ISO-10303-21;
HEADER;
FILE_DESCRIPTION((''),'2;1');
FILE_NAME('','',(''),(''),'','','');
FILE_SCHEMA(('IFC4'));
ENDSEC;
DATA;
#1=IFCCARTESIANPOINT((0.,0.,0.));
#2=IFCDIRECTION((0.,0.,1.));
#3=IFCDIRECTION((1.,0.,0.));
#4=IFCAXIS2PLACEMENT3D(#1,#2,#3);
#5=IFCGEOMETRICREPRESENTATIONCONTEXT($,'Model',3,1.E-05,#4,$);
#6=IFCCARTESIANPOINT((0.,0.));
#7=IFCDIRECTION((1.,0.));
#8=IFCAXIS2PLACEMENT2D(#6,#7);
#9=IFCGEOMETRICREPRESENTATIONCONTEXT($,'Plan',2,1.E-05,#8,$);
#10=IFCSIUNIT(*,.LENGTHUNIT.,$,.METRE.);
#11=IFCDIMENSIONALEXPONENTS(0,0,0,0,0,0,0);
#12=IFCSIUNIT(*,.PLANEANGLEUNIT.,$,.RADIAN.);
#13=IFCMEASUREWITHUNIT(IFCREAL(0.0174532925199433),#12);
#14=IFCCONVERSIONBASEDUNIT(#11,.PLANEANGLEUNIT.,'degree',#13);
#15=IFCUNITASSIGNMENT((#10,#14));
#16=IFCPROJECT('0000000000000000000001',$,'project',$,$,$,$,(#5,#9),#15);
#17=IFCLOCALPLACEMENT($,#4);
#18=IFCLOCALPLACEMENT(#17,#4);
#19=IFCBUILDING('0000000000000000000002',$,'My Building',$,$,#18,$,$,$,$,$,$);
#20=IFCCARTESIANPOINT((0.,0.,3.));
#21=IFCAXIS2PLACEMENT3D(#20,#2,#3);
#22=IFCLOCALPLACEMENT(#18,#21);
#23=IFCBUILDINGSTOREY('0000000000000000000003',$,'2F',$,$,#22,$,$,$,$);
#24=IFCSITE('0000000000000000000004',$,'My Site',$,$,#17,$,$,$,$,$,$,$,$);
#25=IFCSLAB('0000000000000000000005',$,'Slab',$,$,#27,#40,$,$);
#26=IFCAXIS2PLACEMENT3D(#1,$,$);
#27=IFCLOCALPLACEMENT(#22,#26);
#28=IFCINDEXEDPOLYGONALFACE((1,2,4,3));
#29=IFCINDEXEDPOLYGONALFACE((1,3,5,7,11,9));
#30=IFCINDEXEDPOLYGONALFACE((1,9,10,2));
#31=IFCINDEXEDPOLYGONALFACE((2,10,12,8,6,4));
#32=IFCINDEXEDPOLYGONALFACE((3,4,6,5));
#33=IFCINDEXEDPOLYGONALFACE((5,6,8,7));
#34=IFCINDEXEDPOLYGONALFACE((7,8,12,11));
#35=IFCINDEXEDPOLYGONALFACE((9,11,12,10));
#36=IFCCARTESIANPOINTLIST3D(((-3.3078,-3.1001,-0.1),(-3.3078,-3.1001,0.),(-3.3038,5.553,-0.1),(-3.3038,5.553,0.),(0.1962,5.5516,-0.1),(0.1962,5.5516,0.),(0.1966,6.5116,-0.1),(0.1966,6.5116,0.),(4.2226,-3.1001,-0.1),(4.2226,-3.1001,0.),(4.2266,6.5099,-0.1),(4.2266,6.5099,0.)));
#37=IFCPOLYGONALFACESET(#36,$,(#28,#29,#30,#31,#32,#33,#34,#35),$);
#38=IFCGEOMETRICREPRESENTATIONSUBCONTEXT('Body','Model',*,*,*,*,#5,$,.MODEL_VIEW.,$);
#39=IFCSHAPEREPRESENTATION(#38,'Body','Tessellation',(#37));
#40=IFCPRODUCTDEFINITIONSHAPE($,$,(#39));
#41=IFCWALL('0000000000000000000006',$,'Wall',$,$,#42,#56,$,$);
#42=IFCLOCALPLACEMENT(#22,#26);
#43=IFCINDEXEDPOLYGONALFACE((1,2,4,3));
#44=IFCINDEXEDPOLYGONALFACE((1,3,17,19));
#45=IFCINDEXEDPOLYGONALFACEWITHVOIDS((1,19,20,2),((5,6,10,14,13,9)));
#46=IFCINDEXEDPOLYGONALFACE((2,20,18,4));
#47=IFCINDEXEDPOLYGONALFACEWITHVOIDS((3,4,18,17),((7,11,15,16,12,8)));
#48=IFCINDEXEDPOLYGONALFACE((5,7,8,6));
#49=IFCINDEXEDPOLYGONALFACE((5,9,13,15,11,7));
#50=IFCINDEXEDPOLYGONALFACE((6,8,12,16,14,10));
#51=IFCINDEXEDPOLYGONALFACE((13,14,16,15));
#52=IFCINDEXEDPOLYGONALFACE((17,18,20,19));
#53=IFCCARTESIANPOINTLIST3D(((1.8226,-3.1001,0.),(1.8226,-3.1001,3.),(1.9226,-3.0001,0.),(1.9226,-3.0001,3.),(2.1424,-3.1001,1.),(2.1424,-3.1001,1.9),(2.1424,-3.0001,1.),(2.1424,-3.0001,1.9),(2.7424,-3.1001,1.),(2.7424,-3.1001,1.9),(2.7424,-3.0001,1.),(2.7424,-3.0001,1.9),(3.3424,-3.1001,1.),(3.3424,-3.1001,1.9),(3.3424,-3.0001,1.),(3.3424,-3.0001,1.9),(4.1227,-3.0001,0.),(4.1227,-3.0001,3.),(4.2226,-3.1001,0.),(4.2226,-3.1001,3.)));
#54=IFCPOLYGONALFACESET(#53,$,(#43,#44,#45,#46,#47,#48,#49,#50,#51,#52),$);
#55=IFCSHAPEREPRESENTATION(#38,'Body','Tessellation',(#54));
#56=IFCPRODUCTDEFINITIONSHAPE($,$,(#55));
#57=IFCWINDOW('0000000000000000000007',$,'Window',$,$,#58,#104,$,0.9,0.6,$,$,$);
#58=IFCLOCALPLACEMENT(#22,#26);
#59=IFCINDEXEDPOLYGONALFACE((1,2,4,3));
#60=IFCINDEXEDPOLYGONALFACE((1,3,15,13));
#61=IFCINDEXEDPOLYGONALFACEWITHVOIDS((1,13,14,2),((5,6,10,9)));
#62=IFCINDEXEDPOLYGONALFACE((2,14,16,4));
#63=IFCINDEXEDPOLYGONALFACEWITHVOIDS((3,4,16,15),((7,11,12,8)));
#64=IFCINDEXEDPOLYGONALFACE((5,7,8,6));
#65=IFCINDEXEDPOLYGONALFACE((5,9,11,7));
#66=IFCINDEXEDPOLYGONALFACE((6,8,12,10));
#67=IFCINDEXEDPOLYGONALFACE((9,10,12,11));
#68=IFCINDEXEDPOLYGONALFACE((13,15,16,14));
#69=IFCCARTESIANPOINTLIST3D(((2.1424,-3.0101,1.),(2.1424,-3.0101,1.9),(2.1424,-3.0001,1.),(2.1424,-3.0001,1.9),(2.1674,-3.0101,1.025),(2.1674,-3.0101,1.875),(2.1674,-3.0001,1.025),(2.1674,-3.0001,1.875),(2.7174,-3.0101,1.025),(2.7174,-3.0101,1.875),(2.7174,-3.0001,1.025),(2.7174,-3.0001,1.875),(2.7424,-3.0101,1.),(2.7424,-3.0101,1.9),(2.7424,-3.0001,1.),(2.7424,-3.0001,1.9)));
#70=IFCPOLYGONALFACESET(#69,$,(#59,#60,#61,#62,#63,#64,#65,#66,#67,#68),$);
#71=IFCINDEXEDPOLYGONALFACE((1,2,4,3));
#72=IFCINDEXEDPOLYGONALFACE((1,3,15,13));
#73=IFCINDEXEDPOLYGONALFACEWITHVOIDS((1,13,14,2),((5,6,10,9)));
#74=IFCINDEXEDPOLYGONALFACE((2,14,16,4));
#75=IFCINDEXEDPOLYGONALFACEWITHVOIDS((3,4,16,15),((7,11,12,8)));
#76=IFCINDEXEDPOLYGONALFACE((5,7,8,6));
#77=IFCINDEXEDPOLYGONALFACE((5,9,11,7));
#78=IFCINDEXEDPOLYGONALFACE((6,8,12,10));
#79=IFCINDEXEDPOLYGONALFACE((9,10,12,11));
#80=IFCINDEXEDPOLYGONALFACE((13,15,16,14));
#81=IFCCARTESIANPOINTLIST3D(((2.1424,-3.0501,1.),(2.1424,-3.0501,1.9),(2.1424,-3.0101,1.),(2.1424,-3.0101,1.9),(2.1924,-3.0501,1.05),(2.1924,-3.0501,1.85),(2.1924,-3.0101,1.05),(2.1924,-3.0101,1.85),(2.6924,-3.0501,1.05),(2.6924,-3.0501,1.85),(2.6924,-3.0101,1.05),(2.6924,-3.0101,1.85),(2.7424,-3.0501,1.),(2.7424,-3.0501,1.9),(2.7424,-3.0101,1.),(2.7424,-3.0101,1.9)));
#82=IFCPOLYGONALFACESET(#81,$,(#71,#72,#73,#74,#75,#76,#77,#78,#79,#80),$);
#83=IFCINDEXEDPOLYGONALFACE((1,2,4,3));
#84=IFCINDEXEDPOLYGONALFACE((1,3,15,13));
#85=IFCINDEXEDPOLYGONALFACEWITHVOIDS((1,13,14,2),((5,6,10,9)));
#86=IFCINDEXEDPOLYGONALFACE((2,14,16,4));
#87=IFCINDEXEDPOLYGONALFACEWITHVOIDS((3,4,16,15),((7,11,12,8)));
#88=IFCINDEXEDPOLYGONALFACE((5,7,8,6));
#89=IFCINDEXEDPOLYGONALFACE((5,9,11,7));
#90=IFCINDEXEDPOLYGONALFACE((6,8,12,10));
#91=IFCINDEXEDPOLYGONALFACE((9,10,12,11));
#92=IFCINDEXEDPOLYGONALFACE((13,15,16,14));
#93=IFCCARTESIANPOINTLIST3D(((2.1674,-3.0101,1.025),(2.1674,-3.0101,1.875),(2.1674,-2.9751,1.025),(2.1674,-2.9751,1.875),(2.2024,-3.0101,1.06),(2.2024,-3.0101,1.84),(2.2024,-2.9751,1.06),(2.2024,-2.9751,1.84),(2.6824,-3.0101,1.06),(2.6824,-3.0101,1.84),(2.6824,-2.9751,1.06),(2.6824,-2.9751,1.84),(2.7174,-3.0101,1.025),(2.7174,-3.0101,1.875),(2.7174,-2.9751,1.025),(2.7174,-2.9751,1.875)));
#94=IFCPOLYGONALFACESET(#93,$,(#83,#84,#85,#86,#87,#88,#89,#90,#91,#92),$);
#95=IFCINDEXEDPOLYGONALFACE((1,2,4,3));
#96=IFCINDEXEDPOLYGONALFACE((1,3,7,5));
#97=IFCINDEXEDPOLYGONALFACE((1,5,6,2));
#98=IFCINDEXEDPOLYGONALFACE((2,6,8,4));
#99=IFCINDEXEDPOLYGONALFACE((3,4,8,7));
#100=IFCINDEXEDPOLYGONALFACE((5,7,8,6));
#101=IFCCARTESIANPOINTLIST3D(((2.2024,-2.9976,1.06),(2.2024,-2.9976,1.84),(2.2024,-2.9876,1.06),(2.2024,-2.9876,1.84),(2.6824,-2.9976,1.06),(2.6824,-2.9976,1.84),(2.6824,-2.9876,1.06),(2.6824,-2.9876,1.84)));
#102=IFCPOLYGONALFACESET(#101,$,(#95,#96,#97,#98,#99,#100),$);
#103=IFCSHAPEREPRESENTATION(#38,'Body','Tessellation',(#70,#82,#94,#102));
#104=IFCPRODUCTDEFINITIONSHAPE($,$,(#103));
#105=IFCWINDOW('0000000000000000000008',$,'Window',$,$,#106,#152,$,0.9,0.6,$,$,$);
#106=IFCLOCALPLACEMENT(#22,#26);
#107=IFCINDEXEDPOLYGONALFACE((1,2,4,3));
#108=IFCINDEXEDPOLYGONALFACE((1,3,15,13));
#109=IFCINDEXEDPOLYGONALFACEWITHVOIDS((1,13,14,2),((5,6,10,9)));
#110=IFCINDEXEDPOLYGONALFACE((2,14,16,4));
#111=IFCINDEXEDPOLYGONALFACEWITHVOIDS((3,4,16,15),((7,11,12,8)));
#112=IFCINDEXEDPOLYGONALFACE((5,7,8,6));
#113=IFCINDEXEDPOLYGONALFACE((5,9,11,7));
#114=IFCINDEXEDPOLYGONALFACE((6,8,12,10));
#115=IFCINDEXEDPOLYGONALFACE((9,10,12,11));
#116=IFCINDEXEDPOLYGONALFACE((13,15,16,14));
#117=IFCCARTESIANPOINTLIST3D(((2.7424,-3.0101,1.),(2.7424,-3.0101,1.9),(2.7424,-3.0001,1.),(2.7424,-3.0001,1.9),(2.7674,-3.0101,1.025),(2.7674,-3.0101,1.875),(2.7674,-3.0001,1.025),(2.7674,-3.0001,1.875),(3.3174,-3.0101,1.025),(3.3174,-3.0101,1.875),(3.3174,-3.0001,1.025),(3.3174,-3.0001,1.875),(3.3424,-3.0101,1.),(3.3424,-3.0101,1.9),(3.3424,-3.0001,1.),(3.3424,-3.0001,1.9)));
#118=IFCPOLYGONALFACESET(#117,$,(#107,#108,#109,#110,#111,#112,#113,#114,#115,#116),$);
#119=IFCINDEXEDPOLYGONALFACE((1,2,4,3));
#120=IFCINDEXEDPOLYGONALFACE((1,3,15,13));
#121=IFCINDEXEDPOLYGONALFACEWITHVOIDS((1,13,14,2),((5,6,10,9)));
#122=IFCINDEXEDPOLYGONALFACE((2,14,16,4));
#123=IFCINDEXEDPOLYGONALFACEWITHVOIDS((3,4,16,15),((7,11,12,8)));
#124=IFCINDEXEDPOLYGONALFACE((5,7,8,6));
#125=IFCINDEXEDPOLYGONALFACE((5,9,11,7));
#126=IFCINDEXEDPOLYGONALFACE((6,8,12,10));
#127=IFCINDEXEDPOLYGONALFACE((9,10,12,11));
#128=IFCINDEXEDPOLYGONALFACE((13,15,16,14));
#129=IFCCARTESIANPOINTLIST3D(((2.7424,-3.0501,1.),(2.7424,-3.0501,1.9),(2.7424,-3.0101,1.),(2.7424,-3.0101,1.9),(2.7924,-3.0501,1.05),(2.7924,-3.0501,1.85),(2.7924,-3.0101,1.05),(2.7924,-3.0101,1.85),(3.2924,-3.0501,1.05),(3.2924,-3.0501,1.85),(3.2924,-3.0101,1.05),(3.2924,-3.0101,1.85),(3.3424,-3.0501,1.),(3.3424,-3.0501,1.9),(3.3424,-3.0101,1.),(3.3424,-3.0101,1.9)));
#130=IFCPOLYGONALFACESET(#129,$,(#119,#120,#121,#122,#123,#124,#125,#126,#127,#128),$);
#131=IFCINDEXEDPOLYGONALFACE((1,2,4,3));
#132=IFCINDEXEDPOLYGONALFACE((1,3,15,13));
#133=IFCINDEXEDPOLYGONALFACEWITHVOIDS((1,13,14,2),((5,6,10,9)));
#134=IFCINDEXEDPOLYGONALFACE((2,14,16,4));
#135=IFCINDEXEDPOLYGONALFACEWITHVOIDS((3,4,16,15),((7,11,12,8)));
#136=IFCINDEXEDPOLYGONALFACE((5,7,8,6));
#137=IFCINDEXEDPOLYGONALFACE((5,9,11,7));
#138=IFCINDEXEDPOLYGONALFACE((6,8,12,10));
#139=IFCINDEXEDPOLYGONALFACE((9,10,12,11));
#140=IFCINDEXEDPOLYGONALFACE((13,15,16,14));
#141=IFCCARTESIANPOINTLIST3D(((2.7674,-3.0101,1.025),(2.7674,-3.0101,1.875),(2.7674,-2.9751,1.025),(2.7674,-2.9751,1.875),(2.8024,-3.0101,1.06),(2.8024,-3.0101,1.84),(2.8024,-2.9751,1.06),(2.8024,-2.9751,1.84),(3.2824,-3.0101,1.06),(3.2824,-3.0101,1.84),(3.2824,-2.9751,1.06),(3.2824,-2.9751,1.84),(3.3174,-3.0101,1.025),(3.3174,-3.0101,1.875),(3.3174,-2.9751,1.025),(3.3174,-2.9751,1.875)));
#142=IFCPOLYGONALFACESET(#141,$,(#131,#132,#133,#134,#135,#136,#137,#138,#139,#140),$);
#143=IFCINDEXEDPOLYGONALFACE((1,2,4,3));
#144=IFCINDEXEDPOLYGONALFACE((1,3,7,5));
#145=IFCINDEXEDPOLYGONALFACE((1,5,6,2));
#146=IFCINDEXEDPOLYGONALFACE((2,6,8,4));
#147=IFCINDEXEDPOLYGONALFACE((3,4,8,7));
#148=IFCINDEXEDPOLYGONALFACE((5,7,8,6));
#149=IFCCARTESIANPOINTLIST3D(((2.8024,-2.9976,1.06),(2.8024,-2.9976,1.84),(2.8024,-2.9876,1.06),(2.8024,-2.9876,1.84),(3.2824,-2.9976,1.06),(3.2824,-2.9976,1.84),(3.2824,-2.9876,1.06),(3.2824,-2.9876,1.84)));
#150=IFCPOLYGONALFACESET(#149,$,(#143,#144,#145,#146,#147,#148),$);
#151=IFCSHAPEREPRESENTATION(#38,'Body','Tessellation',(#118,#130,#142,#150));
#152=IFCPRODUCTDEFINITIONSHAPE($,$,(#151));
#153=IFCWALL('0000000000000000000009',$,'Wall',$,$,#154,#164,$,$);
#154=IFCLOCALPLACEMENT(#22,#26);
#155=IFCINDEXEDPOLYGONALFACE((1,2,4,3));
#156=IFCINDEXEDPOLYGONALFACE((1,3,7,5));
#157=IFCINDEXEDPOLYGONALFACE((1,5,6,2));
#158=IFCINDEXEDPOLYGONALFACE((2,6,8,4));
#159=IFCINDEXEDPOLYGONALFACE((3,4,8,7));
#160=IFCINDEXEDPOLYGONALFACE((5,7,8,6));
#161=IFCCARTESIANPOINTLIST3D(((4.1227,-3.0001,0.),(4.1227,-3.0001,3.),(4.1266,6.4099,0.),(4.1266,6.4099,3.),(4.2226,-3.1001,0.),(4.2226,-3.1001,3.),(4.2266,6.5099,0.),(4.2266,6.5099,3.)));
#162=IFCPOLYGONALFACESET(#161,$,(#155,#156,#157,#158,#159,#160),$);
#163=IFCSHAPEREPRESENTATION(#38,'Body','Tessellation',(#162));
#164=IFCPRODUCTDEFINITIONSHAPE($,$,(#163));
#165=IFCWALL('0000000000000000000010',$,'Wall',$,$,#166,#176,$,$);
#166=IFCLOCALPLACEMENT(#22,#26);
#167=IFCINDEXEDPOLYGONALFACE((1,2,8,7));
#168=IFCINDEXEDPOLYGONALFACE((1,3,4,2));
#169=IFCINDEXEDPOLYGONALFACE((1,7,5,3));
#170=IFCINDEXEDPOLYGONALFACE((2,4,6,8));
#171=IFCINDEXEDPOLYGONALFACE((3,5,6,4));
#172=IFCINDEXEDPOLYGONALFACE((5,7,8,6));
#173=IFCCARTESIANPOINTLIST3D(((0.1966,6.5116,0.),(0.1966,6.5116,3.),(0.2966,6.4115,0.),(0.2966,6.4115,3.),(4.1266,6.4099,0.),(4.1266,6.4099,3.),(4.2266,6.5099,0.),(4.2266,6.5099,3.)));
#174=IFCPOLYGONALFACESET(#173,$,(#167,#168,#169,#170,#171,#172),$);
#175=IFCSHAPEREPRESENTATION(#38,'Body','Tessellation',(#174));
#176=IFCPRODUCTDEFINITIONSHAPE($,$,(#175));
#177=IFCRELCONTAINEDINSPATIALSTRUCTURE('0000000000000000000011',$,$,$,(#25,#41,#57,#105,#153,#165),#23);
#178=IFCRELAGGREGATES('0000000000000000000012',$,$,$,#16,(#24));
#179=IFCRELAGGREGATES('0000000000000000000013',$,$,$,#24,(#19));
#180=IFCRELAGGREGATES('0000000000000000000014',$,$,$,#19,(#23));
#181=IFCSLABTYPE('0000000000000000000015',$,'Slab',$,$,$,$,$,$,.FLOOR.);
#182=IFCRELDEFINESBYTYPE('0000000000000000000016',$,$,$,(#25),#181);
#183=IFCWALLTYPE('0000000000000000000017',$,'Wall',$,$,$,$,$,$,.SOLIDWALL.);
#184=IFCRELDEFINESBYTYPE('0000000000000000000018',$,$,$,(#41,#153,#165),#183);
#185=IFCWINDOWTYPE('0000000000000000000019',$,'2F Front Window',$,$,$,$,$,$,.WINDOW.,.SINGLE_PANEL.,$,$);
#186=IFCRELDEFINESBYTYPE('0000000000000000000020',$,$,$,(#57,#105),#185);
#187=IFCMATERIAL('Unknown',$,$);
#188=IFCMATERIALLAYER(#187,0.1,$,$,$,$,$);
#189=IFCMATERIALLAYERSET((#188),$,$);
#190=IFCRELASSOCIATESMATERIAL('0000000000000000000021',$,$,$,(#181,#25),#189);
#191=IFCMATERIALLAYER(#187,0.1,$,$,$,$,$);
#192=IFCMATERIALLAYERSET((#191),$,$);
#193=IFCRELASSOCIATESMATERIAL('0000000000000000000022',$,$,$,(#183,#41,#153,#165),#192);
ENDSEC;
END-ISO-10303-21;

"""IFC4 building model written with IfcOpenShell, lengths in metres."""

from ifc_helpers import new_model, entity, si_unit, converted_unit, frame, origin_with_axes, origin_2d_with_axis, place, context, subcontext, project, spatial, line, indexed_curve, outline, extrude, shape, source, transform, mapped, material, layer, layer_set, layer_usage, type_object, type_shapes, element, fill, save


model = new_model("IFC4")

# Units and contexts
model_context = context("Model", 3, precision=1e-05, world=origin_with_axes())
plan_context = context("Plan", 2, precision=1e-05, world=origin_2d_with_axis())
body_context_1 = subcontext(model_context, "Body", "Model", "MODEL_VIEW")
body_context_2 = subcontext(plan_context, "Body", "Plan", "PLAN_VIEW")
ifc_project = project(units=[si_unit("LENGTHUNIT", "METRE"), converted_unit("PLANEANGLEUNIT", "degree", entity("IfcReal", 0.0174532925199433), si_unit("PLANEANGLEUNIT", "RADIAN"), dimensions=[0, 0, 0, 0, 0, 0, 0])], contexts=[model_context, plan_context])

# Site, building, storey
site_placement = place(None, origin_with_axes())
site = spatial("IfcSite", under=ifc_project, at=site_placement, Name="My Site")
building_placement = place(site_placement, origin_with_axes())
building = spatial("IfcBuilding", under=site, at=building_placement, Name="My Building")
storey_placement = place(building_placement, frame((0.0, 0.0, 3.0), z_axis=(0.0, 0.0, 1.0), x_axis=(1.0, 0.0, 0.0)))
storey = spatial("IfcBuildingStorey", under=building, at=storey_placement, Name="2F")

# Slab
ifc_material = material(Name="Unknown")
ifc_layer_1 = layer(ifc_material, 0.1)
ifc_layer_set_1 = layer_set([ifc_layer_1])
ifc_layer_usage_1 = layer_usage(ifc_layer_set_1, "AXIS3", "POSITIVE", -0.1)
slab_type = type_object("IfcSlabType", Name="Slab", PredefinedType="FLOOR", material=ifc_layer_set_1)
slab_placement = place(storey_placement, frame((-3.3078, -3.1001, 0.0), z_axis=(0.0, 0.0, 1.0), x_axis=(1.0, 0.0, 0.0)))
element("IfcSlab", 1, at=slab_placement, inside=storey, type_object=slab_type, material=ifc_layer_usage_1, Name="Slab", context=body_context_1, shape_type="SweptSolid", body=[
    extrude(outline(indexed_curve([(0.0, 0.0), (7.5304, 0.0), (7.5344, 9.61), (3.5044, 9.6117), (3.504, 8.6517), (0.004, 8.6531), (0.0, 0.0)])), frame((0.0, 0.0, -0.1), z_axis=(0.0, 0.0, 1.0), x_axis=(1.0, 0.0, 0.0)), (0.0, 0.0, 1.0), 0.1),
])

# Wall, openings, windows
ifc_layer_2 = layer(ifc_material, 0.1)
ifc_layer_set_2 = layer_set([ifc_layer_2])
ifc_layer_usage_2 = layer_usage(ifc_layer_set_2, "AXIS2", "POSITIVE", 0.0)
wall_type = type_object("IfcWallType", Name="Wall", PredefinedType="SOLIDWALL", material=ifc_layer_set_2)
wall_1_placement = place(storey_placement, frame((1.8226, -3.1001, 0.0), z_axis=(0.0, 0.0, 1.0), x_axis=(1.0, 0.0, 0.0)))
wall_1 = element("IfcWall", 2, at=wall_1_placement, inside=storey, type_object=wall_type, material=ifc_layer_usage_2, Name="Wall", context=body_context_1, shape_type="SweptSolid", body=[
    extrude(outline(indexed_curve([(0.0, 0.0), (0.1, 0.1), (2.3, 0.1), (2.4, 0.0)], segments=[line(1, 2, 3, 4, 1)])), origin_with_axes(), (0.0, 0.0, 1.0), 3.0),
])
shared_shape_1 = source(origin_with_axes(), body_context_1, "Body", "SweptSolid", [
    extrude(outline(indexed_curve([(0.0, 0.0), (0.6, 0.0), (0.6, 0.9), (0.0, 0.9)], segments=[line(1, 2, 3, 4, 1)])), frame((0.0, -0.6, 0.0), z_axis=(0.0, -1.0, 0.0), x_axis=(1.0, 0.0, 0.0)), (0.0, 0.0, -1.0), 1.2),
])
opening_1_placement = place(wall_1_placement, frame((0.3197, 0.0, 1.0), z_axis=(0.0, 0.0, 1.0), x_axis=(1.0, 0.0, 0.0)))
opening_1 = element("IfcOpeningElement", 3, at=opening_1_placement, cuts=wall_1, PredefinedType="OPENING", context=body_context_1, shape_type="MappedRepresentation", body=[
    mapped(shared_shape_1, transform((0.0, 0.0, 0.0), x_axis=(1.0, 0.0, 0.0), y_axis=(0.0, 1.0, 0.0), z_axis=(0.0, 0.0, 1.0), scale=1.0)),
])
opening_2_placement = place(wall_1_placement, frame((0.9197, 0.0, 1.0), z_axis=(0.0, 0.0, 1.0), x_axis=(1.0, 0.0, 0.0)))
opening_2 = element("IfcOpeningElement", 4, at=opening_2_placement, cuts=wall_1, PredefinedType="OPENING", context=body_context_1, shape_type="MappedRepresentation", body=[
    mapped(shared_shape_1, transform((0.0, 0.0, 0.0), x_axis=(1.0, 0.0, 0.0), y_axis=(0.0, 1.0, 0.0), z_axis=(0.0, 0.0, 1.0), scale=1.0)),
])
window_type_1 = type_object("IfcWindowType", Name="2F Front Window", PartitioningType="SINGLE_PANEL", PredefinedType="WINDOW")
shared_shape_2 = source(origin_with_axes(), body_context_1, "Body", "SweptSolid", [
    extrude(outline(indexed_curve([(0.0, 0.0), (0.6, 0.0), (0.6, 0.9), (0.0, 0.9)], segments=[line(1, 2, 3, 4, 1)]), holes=[indexed_curve([(0.025, 0.025), (0.575, 0.025), (0.575, 0.875), (0.025, 0.875)], segments=[line(1, 2, 3, 4, 1)])]), frame((0.0, 0.09, 0.0), z_axis=(0.0, -1.0, 0.0), x_axis=(1.0, 0.0, 0.0)), (0.0, 0.0, -1.0), 0.01),
    extrude(outline(indexed_curve([(0.0, 0.0), (0.6, 0.0), (0.6, 0.9), (0.0, 0.9)], segments=[line(1, 2, 3, 4, 1)]), holes=[indexed_curve([(0.05, 0.05), (0.55, 0.05), (0.55, 0.85), (0.05, 0.85)], segments=[line(1, 2, 3, 4, 1)])]), frame((0.0, 0.05, 0.0), z_axis=(0.0, -1.0, 0.0), x_axis=(1.0, 0.0, 0.0)), (0.0, 0.0, -1.0), 0.04),
    extrude(outline(indexed_curve([(0.0, 0.0), (0.55, 0.0), (0.55, 0.85), (0.0, 0.85)], segments=[line(1, 2, 3, 4, 1)]), holes=[indexed_curve([(0.035, 0.035), (0.515, 0.035), (0.515, 0.815), (0.035, 0.815)], segments=[line(1, 2, 3, 4, 1)])]), frame((0.025, 0.09, 0.025), z_axis=(0.0, -1.0, 0.0), x_axis=(1.0, 0.0, 0.0)), (0.0, 0.0, -1.0), 0.035),
    extrude(outline(indexed_curve([(0.035, 0.035), (0.515, 0.035), (0.515, 0.815), (0.035, 0.815)], segments=[line(1, 2, 3, 4, 1)])), frame((0.025, 0.1025, 0.025), z_axis=(0.0, -1.0, 0.0), x_axis=(1.0, 0.0, 0.0)), (0.0, 0.0, -1.0), 0.01),
])
shared_shape_3 = source(origin_with_axes(), body_context_2, "Body", "Curve2D", [
    entity("IfcIndexedPolyCurve", entity("IfcCartesianPointList2D", [[0.05, 0.05], [0.55, 0.05]])),
    entity("IfcIndexedPolyCurve", entity("IfcCartesianPointList2D", [[0.0, 0.1], [0.025, 0.1], [0.025, 0.09], [0.05, 0.09], [0.05, 0.05], [0.0, 0.05]]), [entity("IfcLineIndex", [1, 2, 3, 4, 5, 6, 1])]),
    entity("IfcIndexedPolyCurve", entity("IfcCartesianPointList2D", [[0.6, 0.1], [0.575, 0.1], [0.575, 0.09], [0.55, 0.09], [0.55, 0.05], [0.6, 0.05]]), [entity("IfcLineIndex", [1, 2, 3, 4, 5, 6, 1])]),
    entity("IfcIndexedPolyCurve", entity("IfcCartesianPointList2D", [[0.025, 0.09], [0.06, 0.09], [0.06, 0.125], [0.025, 0.125]]), [entity("IfcLineIndex", [1, 2, 3, 4, 1])]),
    entity("IfcIndexedPolyCurve", entity("IfcCartesianPointList2D", [[0.575, 0.09], [0.54, 0.09], [0.54, 0.125], [0.575, 0.125]]), [entity("IfcLineIndex", [1, 2, 3, 4, 1])]),
    entity("IfcIndexedPolyCurve", entity("IfcCartesianPointList2D", [[0.06, 0.09], [0.54, 0.09]])),
    entity("IfcIndexedPolyCurve", entity("IfcCartesianPointList2D", [[0.06, 0.125], [0.54, 0.125]])),
    entity("IfcIndexedPolyCurve", entity("IfcCartesianPointList2D", [[0.06, 0.1075], [0.54, 0.1075]])),
])
type_shapes(window_type_1, [shared_shape_2, shared_shape_3])
window_1_placement = place(opening_1_placement, origin_with_axes())
window_1 = element("IfcWindow", 5, at=window_1_placement, inside=storey, type_object=window_type_1, Name="Window", OverallHeight=0.9, OverallWidth=0.6, shapes=[
    shape(body_context_1, "Body", "MappedRepresentation", [mapped(shared_shape_2, transform((0.0, 0.0, 0.0), x_axis=(1.0, 0.0, 0.0), y_axis=(0.0, 1.0, 0.0), z_axis=(0.0, 0.0, 1.0), scale=1.0))]),
    shape(body_context_2, "Body", "MappedRepresentation", [mapped(shared_shape_3, transform((0.0, 0.0, 0.0), x_axis=(1.0, 0.0, 0.0), y_axis=(0.0, 1.0, 0.0), z_axis=(0.0, 0.0, 1.0), scale=1.0))]),
])
fill(opening_1, window_1)
window_2_placement = place(opening_2_placement, origin_with_axes())
window_2 = element("IfcWindow", 6, at=window_2_placement, inside=storey, type_object=window_type_1, Name="Window", OverallHeight=0.9, OverallWidth=0.6, shapes=[
    shape(body_context_1, "Body", "MappedRepresentation", [mapped(shared_shape_2, transform((0.0, 0.0, 0.0), x_axis=(1.0, 0.0, 0.0), y_axis=(0.0, 1.0, 0.0), z_axis=(0.0, 0.0, 1.0), scale=1.0))]),
    shape(body_context_2, "Body", "MappedRepresentation", [mapped(shared_shape_3, transform((0.0, 0.0, 0.0), x_axis=(1.0, 0.0, 0.0), y_axis=(0.0, 1.0, 0.0), z_axis=(0.0, 0.0, 1.0), scale=1.0))]),
])
fill(opening_2, window_2)

# Walls
ifc_layer_usage_3 = layer_usage(ifc_layer_set_2, "AXIS2", "POSITIVE", 0.0)
wall_2_placement = place(storey_placement, frame((4.2226, -3.1001, 0.0), z_axis=(0.0, 0.0, 1.0), x_axis=(0.000415, 1.0, 0.0)))
element("IfcWall", 7, at=wall_2_placement, inside=storey, type_object=wall_type, material=ifc_layer_usage_3, Name="Wall", context=body_context_1, shape_type="SweptSolid", body=[
    extrude(outline(indexed_curve([(0.0, 0.0), (0.1, 0.1), (9.51, 0.1), (9.61, 0.0)], segments=[line(1, 2, 3, 4, 1)])), origin_with_axes(), (0.0, 0.0, 1.0), 3.0),
])
ifc_layer_usage_4 = layer_usage(ifc_layer_set_2, "AXIS2", "POSITIVE", 0.0)
wall_3_placement = place(storey_placement, frame((4.2266, 6.5099, 0.0), z_axis=(0.0, 0.0, 1.0), x_axis=(-1.0, 0.000415, 0.0)))
element("IfcWall", 8, at=wall_3_placement, inside=storey, type_object=wall_type, material=ifc_layer_usage_4, Name="Wall", context=body_context_1, shape_type="SweptSolid", body=[
    extrude(outline(indexed_curve([(0.0, 0.0), (0.1, 0.1), (3.93, 0.1), (4.03, 0.0)], segments=[line(1, 2, 3, 4, 1)])), origin_with_axes(), (0.0, 0.0, 1.0), 3.0),
])

save(model, "model.ifc")
